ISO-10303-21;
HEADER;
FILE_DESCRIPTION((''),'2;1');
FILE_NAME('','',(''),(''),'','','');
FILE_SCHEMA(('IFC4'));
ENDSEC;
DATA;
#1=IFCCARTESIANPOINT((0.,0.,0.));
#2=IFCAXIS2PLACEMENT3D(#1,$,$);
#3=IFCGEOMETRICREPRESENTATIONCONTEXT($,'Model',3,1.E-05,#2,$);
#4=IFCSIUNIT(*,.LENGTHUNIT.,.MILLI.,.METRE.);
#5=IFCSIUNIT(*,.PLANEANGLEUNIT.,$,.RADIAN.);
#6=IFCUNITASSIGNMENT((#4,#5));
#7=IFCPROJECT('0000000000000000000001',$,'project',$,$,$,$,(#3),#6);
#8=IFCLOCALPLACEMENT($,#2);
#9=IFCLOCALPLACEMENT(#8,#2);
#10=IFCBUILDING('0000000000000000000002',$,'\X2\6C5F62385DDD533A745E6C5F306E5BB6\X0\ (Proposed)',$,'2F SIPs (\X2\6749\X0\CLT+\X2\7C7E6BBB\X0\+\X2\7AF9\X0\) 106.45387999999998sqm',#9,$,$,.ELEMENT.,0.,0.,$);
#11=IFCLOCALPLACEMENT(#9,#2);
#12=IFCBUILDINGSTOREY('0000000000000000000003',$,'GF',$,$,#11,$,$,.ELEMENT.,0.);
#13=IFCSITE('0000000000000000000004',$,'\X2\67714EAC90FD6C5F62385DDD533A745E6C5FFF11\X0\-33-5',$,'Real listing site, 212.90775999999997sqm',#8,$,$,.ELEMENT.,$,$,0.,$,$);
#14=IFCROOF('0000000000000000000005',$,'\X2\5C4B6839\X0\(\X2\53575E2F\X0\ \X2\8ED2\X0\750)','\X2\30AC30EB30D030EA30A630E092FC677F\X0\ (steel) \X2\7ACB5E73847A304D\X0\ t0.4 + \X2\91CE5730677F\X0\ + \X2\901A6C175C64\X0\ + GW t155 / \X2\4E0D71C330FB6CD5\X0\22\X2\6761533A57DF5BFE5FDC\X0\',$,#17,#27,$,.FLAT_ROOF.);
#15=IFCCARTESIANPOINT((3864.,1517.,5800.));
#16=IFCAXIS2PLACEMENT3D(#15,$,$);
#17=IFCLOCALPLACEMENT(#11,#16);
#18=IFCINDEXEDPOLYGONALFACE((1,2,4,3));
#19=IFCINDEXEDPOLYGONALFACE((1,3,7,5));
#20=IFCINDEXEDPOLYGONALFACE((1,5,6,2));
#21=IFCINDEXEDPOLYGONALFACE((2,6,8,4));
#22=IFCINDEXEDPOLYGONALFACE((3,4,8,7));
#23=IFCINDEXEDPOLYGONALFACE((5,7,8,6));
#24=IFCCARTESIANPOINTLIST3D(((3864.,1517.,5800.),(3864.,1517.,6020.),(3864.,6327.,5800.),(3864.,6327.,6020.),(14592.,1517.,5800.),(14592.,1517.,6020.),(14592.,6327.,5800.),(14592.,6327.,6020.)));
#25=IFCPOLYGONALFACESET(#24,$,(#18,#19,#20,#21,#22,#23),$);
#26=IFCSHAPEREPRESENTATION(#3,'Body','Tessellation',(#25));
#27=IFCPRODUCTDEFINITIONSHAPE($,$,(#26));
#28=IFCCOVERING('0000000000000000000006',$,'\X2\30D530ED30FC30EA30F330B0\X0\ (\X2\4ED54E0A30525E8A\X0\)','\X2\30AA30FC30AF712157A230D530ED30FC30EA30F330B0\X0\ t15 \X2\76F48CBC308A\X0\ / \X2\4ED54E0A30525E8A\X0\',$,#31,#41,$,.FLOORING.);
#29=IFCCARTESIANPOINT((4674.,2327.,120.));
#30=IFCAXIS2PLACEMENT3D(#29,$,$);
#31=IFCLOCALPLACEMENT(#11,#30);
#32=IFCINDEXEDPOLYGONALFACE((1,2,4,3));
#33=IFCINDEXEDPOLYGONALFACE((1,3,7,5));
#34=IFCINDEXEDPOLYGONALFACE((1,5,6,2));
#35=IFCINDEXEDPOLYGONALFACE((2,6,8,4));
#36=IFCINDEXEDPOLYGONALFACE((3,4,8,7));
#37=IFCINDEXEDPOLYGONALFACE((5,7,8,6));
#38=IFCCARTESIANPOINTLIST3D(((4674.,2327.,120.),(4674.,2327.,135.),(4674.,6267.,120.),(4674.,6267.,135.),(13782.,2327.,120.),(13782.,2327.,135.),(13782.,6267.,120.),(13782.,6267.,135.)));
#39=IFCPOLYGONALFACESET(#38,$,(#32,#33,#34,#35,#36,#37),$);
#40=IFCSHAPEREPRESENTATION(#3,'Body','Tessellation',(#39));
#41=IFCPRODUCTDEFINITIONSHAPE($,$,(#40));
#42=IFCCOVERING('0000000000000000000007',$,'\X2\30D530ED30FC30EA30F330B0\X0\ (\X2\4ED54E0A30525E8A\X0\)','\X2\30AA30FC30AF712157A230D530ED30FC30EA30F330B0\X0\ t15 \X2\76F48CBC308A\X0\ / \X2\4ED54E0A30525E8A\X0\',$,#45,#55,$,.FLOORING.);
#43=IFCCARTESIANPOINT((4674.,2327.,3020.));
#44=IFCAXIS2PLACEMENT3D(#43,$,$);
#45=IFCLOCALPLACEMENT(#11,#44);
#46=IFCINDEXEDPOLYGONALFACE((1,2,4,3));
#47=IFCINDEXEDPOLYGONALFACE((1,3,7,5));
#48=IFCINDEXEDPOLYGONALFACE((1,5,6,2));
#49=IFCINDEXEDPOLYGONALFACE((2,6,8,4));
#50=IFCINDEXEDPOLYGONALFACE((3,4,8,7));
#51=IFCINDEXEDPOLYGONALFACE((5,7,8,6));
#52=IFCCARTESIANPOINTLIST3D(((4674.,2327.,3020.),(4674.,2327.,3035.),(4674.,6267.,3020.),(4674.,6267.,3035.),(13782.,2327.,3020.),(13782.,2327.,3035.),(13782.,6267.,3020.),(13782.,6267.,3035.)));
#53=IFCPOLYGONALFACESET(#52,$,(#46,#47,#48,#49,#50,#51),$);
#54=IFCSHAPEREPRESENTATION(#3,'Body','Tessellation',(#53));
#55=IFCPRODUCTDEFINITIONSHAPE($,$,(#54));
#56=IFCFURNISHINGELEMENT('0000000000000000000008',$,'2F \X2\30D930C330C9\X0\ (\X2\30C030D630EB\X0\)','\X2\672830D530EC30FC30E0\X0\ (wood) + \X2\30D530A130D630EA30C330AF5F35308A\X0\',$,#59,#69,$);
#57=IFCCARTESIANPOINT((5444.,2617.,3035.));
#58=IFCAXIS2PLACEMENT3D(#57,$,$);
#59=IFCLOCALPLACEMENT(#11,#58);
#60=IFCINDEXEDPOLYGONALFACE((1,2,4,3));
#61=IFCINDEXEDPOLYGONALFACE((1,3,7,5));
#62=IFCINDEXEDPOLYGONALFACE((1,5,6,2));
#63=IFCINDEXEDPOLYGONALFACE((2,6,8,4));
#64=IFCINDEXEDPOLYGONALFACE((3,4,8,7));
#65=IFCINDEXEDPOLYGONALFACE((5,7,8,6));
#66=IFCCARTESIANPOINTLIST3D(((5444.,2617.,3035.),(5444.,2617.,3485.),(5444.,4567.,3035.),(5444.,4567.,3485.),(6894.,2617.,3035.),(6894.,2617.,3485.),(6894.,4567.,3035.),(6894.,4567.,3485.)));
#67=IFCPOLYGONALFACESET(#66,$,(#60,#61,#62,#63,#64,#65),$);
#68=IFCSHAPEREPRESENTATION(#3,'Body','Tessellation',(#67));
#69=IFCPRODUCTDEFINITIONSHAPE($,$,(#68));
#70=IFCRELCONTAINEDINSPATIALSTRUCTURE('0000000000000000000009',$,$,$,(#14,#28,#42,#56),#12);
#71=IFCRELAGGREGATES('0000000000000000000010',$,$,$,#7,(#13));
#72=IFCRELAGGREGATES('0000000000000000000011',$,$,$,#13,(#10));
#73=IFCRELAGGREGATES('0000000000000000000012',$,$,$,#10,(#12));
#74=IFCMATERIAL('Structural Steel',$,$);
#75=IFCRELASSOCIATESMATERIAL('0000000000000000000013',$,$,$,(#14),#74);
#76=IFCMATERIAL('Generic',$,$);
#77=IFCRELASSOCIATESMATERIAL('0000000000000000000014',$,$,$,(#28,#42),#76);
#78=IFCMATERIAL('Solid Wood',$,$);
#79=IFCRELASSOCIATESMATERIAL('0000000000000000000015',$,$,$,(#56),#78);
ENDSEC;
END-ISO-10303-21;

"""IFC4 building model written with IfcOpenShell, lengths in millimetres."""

from ifc_helpers import new_model, si_unit, frame, frame_2d, origin, place, context, project, spatial, rectangle, extrude, material, element, save


model = new_model("IFC4")

# Units and contexts
model_context = context("Model", 3, precision=1e-05, world=origin())
ifc_project = project(units=[si_unit("LENGTHUNIT", "METRE", prefix="MILLI"), si_unit("PLANEANGLEUNIT", "RADIAN")], contexts=[model_context])

# Site, building, storey
site_placement = place(None, origin())
site = spatial("IfcSite", under=ifc_project, at=site_placement, Name="東京都江戸川区瑞江１-33-5", ObjectType="Real listing site, 212.90775999999997sqm", CompositionType="ELEMENT", RefElevation=0.0)
building_placement = place(site_placement, origin())
building = spatial("IfcBuilding", under=site, at=building_placement, Name="江戸川区瑞江の家 (Proposed)", ObjectType="2F SIPs (杉CLT+籾殻+竹) 106.45387999999998sqm", CompositionType="ELEMENT", ElevationOfRefHeight=0.0, ElevationOfTerrain=0.0)
storey_placement = place(building_placement, origin())
storey = spatial("IfcBuildingStorey", under=building, at=storey_placement, Name="GF", CompositionType="ELEMENT", Elevation=0.0)

# Shared definitions
ifc_material_1 = material(Name="Solid Wood")

# Roof
ifc_material_2 = material(Name="Structural Steel")
for number, where, name in (
    (1, (3864.0, 1517.0, 5800.0), "屋根(南帯 軒750)"),
):
    element("IfcRoof", number, at=place(storey_placement, frame(where)), inside=storey, material=ifc_material_2, Name=name, Description="ガルバリウム鋼板 (steel) 立平葺き t0.4 + 野地板 + 通気層 + GW t155 / 不燃・法22条区域対応", PredefinedType="FLAT_ROOF", context=model_context, shape_type="SweptSolid", body=[
        extrude(rectangle(XDim=10728.0, YDim=4810.0, at=frame_2d((5364.0, 2405.0))), frame((3864.0, 1517.0, 5800.0)), (0.0, 0.0, 1.0), 220.0),
    ])

# Coverings
ifc_material_3 = material(Name="Generic")
covering_1_placement = place(storey_placement, frame((4674.0, 2327.0, 120.0)))
element("IfcCovering", 2, at=covering_1_placement, inside=storey, material=ifc_material_3, Name="フローリング (仕上げ床)", Description="オーク無垢フローリング t15 直貼り / 仕上げ床", PredefinedType="FLOORING", context=model_context, shape_type="SweptSolid", body=[
    extrude(rectangle(XDim=9108.0, YDim=3940.0, at=frame_2d((4554.0, 1970.0))), frame((4674.0, 2327.0, 120.0)), (0.0, 0.0, 1.0), 15.0),
])
covering_2_placement = place(storey_placement, frame((4674.0, 2327.0, 3020.0)))
element("IfcCovering", 3, at=covering_2_placement, inside=storey, material=ifc_material_3, Name="フローリング (仕上げ床)", Description="オーク無垢フローリング t15 直貼り / 仕上げ床", PredefinedType="FLOORING", context=model_context, shape_type="SweptSolid", body=[
    extrude(rectangle(XDim=9108.0, YDim=3940.0, at=frame_2d((4554.0, 1970.0))), frame((4674.0, 2327.0, 3020.0)), (0.0, 0.0, 1.0), 15.0),
])

# Furnishing element
furnishing_placement = place(storey_placement, frame((5444.0, 2617.0, 3035.0)))
element("IfcFurnishingElement", 4, at=furnishing_placement, inside=storey, material=ifc_material_1, Name="2F ベッド (ダブル)", Description="木フレーム (wood) + ファブリック張り", context=model_context, shape_type="SweptSolid", body=[
    extrude(rectangle(XDim=1450.0, YDim=1950.0, at=frame_2d((725.0, 975.0))), frame((5444.0, 2617.0, 3035.0)), (0.0, 0.0, 1.0), 450.0),
])

save(model, "model.ifc")
